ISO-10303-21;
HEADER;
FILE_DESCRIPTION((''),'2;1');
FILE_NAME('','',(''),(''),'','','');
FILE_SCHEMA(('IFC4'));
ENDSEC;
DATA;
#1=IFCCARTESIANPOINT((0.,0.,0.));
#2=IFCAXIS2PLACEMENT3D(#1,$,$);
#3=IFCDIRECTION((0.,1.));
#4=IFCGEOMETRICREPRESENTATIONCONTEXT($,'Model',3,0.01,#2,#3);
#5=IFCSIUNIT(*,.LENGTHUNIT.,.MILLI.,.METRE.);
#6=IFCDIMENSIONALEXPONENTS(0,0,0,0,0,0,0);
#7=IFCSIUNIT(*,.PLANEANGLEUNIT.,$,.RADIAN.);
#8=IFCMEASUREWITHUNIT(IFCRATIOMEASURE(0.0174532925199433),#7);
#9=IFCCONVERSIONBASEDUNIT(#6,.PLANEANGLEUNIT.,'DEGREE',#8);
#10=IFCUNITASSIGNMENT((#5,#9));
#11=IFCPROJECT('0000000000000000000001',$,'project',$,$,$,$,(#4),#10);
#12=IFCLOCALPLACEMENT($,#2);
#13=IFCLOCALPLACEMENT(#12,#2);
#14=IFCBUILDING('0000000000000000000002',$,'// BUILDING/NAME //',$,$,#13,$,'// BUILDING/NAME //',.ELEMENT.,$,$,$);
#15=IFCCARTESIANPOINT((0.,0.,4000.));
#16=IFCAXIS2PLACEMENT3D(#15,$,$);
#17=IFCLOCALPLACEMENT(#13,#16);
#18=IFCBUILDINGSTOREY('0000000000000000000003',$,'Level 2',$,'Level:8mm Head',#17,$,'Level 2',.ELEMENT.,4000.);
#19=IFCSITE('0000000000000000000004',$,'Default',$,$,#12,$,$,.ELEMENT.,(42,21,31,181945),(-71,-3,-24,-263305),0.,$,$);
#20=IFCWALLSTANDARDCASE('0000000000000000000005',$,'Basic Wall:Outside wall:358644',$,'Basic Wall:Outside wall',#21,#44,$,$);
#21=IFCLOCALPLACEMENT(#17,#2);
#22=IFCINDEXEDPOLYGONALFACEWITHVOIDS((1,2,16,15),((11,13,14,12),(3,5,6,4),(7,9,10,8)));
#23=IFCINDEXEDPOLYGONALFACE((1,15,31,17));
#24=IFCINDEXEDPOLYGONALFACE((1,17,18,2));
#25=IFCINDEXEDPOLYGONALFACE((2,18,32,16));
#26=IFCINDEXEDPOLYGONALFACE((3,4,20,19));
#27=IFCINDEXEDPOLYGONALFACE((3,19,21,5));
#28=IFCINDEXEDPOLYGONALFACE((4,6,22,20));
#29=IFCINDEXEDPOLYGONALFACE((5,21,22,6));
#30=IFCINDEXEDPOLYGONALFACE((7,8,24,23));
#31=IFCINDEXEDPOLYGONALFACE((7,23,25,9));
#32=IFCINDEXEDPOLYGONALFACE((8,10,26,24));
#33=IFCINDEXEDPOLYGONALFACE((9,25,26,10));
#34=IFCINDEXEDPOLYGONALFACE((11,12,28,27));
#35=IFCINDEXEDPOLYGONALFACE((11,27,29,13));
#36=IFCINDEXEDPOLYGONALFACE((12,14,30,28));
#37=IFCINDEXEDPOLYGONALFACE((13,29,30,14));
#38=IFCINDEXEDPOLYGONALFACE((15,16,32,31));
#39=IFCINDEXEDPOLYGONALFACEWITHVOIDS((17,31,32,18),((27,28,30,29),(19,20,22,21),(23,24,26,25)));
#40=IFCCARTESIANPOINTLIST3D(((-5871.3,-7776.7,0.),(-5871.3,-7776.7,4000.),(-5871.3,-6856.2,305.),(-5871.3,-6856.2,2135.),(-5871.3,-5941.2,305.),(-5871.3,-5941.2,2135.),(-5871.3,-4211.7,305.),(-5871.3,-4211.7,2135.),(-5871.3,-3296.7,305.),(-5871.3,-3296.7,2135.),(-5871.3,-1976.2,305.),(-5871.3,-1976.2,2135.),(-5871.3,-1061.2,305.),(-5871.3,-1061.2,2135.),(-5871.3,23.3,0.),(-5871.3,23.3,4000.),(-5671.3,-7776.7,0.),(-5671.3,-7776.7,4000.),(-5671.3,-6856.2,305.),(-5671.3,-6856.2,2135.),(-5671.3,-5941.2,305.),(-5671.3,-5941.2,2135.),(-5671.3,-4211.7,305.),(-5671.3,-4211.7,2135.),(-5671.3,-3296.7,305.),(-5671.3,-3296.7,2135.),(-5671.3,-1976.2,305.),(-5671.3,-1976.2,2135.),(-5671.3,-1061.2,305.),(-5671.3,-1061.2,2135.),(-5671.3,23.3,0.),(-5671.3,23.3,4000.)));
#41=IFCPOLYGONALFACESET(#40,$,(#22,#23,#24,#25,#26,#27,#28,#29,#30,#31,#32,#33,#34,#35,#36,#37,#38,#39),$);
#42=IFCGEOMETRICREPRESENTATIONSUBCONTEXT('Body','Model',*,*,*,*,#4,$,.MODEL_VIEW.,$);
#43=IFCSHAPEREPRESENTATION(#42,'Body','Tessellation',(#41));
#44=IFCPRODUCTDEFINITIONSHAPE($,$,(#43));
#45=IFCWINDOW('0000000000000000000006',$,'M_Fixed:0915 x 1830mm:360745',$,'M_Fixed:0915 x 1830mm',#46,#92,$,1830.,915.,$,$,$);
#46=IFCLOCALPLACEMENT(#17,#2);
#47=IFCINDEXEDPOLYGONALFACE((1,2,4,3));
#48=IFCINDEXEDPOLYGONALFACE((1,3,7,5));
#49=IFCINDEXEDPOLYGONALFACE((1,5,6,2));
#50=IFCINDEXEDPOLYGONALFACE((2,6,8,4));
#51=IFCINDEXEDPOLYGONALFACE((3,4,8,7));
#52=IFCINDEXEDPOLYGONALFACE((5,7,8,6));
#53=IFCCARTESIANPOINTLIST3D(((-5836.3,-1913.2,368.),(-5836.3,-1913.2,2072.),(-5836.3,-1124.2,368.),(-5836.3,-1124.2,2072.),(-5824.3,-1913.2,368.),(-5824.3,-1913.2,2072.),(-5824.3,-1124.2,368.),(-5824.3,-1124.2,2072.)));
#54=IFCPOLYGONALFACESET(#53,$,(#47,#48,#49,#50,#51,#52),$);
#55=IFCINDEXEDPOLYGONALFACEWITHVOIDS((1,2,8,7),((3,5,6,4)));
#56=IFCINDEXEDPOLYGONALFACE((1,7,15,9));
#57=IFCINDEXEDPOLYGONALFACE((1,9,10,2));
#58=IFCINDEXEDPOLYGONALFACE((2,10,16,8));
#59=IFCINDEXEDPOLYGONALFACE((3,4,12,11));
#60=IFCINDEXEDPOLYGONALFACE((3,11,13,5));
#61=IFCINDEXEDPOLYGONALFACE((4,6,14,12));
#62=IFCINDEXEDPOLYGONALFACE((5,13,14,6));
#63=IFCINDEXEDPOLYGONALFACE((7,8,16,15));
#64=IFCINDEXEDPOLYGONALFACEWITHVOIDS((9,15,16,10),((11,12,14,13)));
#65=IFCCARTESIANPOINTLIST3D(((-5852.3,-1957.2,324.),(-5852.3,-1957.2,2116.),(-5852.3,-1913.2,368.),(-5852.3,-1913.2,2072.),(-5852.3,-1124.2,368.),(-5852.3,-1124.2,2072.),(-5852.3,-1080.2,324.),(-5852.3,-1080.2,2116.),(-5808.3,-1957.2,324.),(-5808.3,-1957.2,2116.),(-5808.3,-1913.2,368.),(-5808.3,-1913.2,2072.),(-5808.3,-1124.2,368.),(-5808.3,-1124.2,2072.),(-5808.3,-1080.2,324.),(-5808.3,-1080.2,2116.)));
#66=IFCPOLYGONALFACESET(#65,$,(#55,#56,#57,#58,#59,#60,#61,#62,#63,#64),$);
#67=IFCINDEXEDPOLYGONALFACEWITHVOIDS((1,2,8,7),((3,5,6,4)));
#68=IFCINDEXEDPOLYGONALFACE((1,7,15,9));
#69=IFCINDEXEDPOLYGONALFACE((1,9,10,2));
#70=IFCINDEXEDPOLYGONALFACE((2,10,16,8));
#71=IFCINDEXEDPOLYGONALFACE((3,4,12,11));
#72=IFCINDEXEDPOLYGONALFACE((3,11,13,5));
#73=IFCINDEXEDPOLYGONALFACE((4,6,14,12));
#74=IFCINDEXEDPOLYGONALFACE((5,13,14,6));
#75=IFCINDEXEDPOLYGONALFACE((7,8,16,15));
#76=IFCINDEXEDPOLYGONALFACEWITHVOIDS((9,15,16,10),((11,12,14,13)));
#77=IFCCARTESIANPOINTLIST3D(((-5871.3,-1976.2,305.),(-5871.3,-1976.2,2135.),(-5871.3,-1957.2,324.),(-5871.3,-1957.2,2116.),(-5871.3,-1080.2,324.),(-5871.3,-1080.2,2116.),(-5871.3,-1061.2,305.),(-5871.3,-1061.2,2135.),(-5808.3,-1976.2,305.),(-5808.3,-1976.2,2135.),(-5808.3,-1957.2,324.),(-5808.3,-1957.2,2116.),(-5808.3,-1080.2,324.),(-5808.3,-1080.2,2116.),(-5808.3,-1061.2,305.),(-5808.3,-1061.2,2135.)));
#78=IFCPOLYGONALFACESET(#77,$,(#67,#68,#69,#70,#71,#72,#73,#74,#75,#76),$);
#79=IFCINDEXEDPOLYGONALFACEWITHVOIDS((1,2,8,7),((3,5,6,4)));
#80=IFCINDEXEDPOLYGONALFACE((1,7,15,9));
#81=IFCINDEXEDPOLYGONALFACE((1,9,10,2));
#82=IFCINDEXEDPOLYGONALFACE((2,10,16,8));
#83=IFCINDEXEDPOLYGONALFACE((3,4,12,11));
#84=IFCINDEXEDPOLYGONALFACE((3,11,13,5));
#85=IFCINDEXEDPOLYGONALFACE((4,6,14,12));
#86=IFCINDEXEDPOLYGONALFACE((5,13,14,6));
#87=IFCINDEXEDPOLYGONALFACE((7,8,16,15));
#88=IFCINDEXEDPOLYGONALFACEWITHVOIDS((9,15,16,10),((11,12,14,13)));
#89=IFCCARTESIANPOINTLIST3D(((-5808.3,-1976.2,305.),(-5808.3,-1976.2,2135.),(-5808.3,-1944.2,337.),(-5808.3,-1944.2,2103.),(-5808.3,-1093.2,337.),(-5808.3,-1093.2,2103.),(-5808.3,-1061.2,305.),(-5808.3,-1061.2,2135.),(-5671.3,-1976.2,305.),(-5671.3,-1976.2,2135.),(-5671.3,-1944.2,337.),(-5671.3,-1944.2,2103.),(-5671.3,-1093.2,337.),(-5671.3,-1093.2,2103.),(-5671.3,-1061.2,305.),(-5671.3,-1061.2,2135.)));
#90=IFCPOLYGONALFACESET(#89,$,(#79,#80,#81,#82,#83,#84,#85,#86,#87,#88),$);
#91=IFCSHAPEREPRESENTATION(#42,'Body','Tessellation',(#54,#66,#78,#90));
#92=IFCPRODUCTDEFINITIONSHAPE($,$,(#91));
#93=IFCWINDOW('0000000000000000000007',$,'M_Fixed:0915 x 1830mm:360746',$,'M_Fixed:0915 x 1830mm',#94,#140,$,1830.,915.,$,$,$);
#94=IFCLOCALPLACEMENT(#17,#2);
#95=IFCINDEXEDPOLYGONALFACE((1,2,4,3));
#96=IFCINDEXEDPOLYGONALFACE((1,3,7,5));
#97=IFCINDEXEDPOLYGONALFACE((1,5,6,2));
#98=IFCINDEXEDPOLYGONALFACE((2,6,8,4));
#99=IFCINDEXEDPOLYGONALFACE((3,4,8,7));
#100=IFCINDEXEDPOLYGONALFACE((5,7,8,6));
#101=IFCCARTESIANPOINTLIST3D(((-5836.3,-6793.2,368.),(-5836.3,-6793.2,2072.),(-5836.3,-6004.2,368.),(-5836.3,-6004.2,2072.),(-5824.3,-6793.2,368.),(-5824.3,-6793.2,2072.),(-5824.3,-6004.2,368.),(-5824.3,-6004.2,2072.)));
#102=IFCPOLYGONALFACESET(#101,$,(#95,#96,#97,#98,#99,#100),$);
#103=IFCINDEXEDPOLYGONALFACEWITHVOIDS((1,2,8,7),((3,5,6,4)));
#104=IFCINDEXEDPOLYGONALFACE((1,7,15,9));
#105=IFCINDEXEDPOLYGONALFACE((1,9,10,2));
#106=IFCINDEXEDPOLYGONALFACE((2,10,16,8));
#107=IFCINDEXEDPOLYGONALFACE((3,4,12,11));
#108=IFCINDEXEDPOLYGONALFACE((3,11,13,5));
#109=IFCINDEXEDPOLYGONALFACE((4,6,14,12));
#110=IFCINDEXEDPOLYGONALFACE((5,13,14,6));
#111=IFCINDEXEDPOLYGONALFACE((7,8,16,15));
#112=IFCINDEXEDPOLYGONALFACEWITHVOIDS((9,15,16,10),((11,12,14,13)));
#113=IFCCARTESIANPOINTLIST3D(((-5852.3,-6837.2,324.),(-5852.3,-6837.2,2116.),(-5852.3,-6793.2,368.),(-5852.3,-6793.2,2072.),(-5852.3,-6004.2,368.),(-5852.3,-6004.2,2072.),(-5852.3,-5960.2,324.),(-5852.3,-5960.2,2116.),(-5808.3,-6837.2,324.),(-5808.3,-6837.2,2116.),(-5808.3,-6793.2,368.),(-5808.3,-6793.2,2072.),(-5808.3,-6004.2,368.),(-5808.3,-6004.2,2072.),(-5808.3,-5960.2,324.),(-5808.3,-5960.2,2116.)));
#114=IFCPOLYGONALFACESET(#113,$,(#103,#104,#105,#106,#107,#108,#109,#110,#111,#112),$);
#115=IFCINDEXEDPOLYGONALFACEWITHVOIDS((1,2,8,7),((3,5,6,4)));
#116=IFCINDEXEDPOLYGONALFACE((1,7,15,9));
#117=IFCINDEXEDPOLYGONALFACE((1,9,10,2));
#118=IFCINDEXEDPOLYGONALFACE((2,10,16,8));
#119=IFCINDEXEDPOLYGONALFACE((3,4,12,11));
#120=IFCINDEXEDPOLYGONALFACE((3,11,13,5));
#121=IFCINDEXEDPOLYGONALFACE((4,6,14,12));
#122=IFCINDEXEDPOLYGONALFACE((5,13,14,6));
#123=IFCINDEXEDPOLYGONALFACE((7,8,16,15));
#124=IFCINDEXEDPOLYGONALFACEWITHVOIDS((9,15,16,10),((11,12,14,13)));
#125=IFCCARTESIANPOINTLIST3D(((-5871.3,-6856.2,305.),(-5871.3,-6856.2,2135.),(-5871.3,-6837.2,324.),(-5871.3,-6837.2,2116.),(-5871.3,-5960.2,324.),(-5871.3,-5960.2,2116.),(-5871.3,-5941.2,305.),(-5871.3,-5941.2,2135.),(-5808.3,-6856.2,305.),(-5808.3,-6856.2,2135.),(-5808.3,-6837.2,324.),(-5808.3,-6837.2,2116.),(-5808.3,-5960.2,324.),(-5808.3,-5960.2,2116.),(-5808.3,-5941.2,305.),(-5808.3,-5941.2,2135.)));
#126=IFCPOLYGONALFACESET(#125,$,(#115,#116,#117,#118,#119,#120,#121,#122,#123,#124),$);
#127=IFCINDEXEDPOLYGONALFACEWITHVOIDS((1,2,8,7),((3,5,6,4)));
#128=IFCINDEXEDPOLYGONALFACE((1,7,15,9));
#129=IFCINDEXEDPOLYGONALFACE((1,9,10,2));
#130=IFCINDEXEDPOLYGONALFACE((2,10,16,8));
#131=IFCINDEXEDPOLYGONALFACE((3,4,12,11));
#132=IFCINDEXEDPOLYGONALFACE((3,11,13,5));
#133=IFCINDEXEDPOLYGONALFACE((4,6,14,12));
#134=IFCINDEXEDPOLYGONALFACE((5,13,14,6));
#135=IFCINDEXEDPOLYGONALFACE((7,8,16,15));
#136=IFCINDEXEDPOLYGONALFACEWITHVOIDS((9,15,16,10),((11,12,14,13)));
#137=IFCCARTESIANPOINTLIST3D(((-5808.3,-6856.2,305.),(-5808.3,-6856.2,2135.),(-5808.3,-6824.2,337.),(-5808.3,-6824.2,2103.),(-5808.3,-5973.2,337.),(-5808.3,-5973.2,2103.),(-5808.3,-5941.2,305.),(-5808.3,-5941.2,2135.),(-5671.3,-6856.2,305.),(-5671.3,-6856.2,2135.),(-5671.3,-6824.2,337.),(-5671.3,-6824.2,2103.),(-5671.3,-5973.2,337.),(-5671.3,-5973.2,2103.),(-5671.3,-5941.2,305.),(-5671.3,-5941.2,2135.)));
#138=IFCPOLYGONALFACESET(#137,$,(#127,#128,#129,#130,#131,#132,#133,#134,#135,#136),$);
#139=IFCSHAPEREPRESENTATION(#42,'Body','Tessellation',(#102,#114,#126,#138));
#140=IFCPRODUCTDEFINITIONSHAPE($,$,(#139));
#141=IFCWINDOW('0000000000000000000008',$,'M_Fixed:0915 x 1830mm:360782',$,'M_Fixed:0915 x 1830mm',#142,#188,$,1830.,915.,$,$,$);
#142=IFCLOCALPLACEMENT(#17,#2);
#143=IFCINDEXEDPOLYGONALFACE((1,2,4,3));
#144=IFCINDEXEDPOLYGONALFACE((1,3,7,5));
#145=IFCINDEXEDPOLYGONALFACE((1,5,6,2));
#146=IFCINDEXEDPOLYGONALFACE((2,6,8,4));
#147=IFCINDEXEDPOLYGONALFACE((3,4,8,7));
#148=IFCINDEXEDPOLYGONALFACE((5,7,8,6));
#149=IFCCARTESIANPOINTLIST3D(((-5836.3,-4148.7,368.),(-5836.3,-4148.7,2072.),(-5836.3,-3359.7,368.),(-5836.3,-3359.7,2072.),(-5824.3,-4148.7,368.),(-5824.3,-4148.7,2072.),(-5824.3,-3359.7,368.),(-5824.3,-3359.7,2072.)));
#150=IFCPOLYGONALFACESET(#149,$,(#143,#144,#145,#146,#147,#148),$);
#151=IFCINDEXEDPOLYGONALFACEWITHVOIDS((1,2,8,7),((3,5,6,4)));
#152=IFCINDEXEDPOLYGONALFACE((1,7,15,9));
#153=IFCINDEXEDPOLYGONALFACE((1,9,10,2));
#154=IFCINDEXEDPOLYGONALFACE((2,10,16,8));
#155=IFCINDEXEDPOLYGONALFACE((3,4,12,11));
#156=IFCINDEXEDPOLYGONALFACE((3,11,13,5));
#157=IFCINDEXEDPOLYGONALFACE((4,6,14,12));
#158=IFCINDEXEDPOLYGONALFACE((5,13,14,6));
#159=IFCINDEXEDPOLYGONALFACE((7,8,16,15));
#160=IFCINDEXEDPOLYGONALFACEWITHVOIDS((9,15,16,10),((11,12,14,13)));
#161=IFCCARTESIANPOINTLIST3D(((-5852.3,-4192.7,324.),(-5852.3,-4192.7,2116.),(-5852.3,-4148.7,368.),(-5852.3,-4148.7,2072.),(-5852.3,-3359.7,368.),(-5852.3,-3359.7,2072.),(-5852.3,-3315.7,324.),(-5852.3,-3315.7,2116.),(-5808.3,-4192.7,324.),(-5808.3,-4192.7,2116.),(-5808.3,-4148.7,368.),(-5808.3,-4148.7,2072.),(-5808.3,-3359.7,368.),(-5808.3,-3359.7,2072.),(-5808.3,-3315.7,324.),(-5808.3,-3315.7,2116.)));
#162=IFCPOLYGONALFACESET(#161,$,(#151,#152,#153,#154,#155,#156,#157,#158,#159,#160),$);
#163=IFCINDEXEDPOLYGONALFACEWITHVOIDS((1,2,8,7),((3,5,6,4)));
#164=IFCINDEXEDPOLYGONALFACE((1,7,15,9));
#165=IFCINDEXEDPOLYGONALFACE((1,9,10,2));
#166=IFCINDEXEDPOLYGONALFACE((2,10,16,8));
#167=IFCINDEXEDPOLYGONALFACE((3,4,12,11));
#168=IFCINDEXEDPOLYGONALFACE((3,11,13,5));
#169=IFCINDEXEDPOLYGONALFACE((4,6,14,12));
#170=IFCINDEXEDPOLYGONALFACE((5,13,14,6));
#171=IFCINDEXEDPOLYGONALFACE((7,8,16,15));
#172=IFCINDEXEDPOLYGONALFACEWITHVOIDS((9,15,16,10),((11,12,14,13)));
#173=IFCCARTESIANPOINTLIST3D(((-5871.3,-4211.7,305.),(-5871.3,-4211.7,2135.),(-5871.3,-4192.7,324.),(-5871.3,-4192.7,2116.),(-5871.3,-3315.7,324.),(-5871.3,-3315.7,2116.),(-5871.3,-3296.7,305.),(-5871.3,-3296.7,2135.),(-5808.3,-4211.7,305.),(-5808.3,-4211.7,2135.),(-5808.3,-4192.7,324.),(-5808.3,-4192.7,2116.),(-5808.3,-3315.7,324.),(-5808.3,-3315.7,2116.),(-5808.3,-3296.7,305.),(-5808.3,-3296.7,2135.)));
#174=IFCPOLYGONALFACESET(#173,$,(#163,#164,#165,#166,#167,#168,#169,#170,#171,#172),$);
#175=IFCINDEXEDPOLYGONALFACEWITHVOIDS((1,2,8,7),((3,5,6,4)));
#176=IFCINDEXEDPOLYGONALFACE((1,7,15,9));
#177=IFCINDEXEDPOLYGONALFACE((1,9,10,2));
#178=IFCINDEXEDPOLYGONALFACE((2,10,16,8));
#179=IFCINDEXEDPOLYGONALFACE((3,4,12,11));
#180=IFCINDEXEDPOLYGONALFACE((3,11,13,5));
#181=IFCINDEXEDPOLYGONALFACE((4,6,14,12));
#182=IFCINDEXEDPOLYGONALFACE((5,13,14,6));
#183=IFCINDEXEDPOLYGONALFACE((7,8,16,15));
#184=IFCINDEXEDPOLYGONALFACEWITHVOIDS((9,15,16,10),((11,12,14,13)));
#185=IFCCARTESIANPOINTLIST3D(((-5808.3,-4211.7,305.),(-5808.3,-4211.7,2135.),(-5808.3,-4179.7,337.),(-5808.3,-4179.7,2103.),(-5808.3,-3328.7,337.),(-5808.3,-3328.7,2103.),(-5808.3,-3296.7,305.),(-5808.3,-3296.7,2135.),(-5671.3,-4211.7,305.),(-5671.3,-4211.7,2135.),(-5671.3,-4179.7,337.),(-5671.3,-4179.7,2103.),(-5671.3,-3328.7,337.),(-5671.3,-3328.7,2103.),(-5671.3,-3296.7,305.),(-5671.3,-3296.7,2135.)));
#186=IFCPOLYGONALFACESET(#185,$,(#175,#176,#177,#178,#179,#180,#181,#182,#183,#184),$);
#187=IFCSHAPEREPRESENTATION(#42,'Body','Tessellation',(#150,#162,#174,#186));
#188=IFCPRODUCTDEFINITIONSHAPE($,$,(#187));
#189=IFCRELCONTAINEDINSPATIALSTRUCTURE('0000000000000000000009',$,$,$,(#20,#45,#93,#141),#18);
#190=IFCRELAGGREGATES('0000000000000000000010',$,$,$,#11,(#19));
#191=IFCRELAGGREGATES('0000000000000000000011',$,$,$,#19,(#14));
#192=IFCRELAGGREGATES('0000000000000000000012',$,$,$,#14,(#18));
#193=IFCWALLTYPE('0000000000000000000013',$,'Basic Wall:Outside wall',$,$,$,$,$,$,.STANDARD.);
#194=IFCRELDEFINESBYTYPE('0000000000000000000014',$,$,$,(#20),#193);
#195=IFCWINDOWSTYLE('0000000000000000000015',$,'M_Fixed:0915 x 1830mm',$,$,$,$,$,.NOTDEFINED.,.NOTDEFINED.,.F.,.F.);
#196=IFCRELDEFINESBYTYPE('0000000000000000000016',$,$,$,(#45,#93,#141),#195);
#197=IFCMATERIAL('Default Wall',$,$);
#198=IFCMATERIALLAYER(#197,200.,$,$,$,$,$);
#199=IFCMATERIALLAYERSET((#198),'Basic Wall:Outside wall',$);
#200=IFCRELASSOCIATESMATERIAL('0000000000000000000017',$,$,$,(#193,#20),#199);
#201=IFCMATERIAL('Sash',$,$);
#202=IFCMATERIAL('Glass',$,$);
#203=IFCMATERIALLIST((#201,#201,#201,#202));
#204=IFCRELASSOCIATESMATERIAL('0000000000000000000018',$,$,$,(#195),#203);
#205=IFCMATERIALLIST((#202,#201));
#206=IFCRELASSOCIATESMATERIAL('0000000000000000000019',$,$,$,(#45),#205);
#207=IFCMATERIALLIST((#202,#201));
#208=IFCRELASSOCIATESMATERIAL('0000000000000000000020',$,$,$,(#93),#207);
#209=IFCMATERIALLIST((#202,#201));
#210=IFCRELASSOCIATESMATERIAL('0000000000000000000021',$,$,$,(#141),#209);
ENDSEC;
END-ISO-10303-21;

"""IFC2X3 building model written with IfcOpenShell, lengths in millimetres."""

from ifc_helpers import new_model, entity, si_unit, converted_unit, direction, frame, frame_2d, origin, place, context, subcontext, project, spatial, polyline, rectangle, outline, extrude, clip, halfspace, source, transform, mapped, material, material_list, layer, layer_set, layer_usage, type_object, type_shapes, element, fill, save


model = new_model("IFC2X3")

# Units and contexts
model_context = context("Model", 3, precision=0.01, world=origin(), true_north=direction((0.0, 1.0)))
body_context = subcontext(model_context, "Body", "Model", "MODEL_VIEW")
ifc_project = project(units=[si_unit("LENGTHUNIT", "METRE", prefix="MILLI"), converted_unit("PLANEANGLEUNIT", "DEGREE", entity("IfcRatioMeasure", 0.0174532925199433), si_unit("PLANEANGLEUNIT", "RADIAN"), dimensions=[0, 0, 0, 0, 0, 0, 0])], contexts=[model_context])

# Site, building, storey
site_placement = place(None, origin())
site = spatial("IfcSite", under=ifc_project, at=site_placement, Name="Default", CompositionType="ELEMENT", RefLatitude=(42, 21, 31, 181945), RefLongitude=(-71, -3, -24, -263305), RefElevation=0.0)
building_placement = place(site_placement, origin())
building = spatial("IfcBuilding", under=site, at=building_placement, Name="// BUILDING/NAME //", LongName="// BUILDING/NAME //", CompositionType="ELEMENT")
storey_placement = place(building_placement, frame((0.0, 0.0, 4000.0)))
storey = spatial("IfcBuildingStorey", under=building, at=storey_placement, Name="Level 2", ObjectType="Level:8mm Head", LongName="Level 2", CompositionType="ELEMENT", Elevation=4000.0)

# Shared definitions
ifc_material_1 = material(Name="Default Wall")
ifc_layer_1 = layer(ifc_material_1, 200.0)
ifc_layer_set_1 = layer_set([ifc_layer_1], Name="Basic Wall:Outside wall")
wall_type_1 = type_object("IfcWallType", Name="Basic Wall:Outside wall", PredefinedType="STANDARD", material=ifc_layer_set_1)
ifc_material_2 = material(Name="Glass")
ifc_material_3 = material(Name="Sash")
ifc_material_list_1 = material_list([ifc_material_3, ifc_material_3, ifc_material_3, ifc_material_2])
window_style = type_object("IfcWindowStyle", Name="M_Fixed:0915 x 1830mm", ConstructionType="NOTDEFINED", OperationType="NOTDEFINED", ParameterTakesPrecedence=False, Sizeable=False, material=ifc_material_list_1)
shared_shape = source(origin(), body_context, "Body", "SweptSolid", [
    extrude(rectangle(XDim=12.0, YDim=789.0, at=frame_2d((0.0, 0.0), x_axis=(1.0, 0.0))), frame((457.5, 159.0, 63.0), z_axis=(0.0, 0.0, 1.0), x_axis=(0.0, -1.0, 0.0)), (0.0, 0.0, 1.0), 1704.0),
    extrude(outline(polyline([(-438.5, -896.0), (438.5, -896.0), (438.5, 896.0), (-438.5, 896.0), (-438.5, -896.0)]), holes=[polyline([(-394.5, -852.0), (-394.5, 852.0), (394.5, 852.0), (394.5, -852.0), (-394.5, -852.0)])]), frame((457.5, 137.0, 915.0), z_axis=(0.0, 1.0, 0.0), x_axis=(1.0, 0.0, 0.0)), (0.0, 0.0, 1.0), 44.0),
    extrude(outline(polyline([(-457.5, -915.0), (457.5, -915.0), (457.5, 915.0), (-457.5, 915.0), (-457.5, -915.0)]), holes=[polyline([(-438.5, -896.0), (-438.5, 896.0), (438.5, 896.0), (438.5, -896.0), (-438.5, -896.0)])]), frame((457.5, 137.0, 915.0), z_axis=(0.0, 1.0, 0.0), x_axis=(1.0, 0.0, 0.0)), (0.0, 0.0, 1.0), 63.0),
    extrude(outline(polyline([(-457.5, -915.0), (457.5, -915.0), (457.5, 915.0), (-457.5, 915.0), (-457.5, -915.0)]), holes=[polyline([(-425.5, -883.0), (-425.5, 883.0), (425.5, 883.0), (425.5, -883.0), (-425.5, -883.0)])]), frame((457.5, 0.0, 915.0), z_axis=(0.0, 1.0, 0.0), x_axis=(1.0, 0.0, 0.0)), (0.0, 0.0, 1.0), 137.0),
])
type_shapes(window_style, [shared_shape])

# Wall, openings, windows
ifc_layer_usage_1 = layer_usage(ifc_layer_set_1, "AXIS2", "NEGATIVE", 100.0)
wall_1_placement = place(storey_placement, frame((-5771.3, -7776.7, 0.0), z_axis=(0.0, 0.0, 1.0), x_axis=(0.0, 1.0, 0.0)))
wall_1 = element("IfcWallStandardCase", 1, at=wall_1_placement, inside=storey, type_object=wall_type_1, material=ifc_layer_usage_1, Name="Basic Wall:Outside wall:358644", ObjectType="Basic Wall:Outside wall", context=body_context, shape_type="Clipping", body=[
    clip(extrude(rectangle(XDim=7800.0, YDim=200.0, at=frame_2d((3900.0, 0.0), x_axis=(-1.0, 0.0))), origin(), (0.0, 0.0, 1.0), 4000.0), halfspace(frame((0.0, 0.0, -4000.0)), True)),
])
opening_1_placement = place(wall_1_placement, frame((5800.5, -100.0, 305.0)))
opening_1 = element("IfcOpeningElement", 2, at=opening_1_placement, cuts=wall_1, ObjectType="Opening", context=body_context, shape_type="SweptSolid", body=[
    extrude(rectangle(XDim=1830.0, YDim=915.0, at=frame_2d((915.0, 457.5), x_axis=(1.0, 0.0))), frame((0.0, 0.0, 0.0), z_axis=(0.0, 1.0, 0.0), x_axis=(0.0, 0.0, 1.0)), (0.0, 0.0, 1.0), 200.0),
])
opening_2_placement = place(wall_1_placement, frame((920.5, -100.0, 305.0)))
opening_2 = element("IfcOpeningElement", 3, at=opening_2_placement, cuts=wall_1, ObjectType="Opening", context=body_context, shape_type="SweptSolid", body=[
    extrude(rectangle(XDim=1830.0, YDim=915.0, at=frame_2d((915.0, 457.5), x_axis=(1.0, 0.0))), frame((0.0, 0.0, 0.0), z_axis=(0.0, 1.0, 0.0), x_axis=(0.0, 0.0, 1.0)), (0.0, 0.0, 1.0), 200.0),
])
opening_3_placement = place(wall_1_placement, frame((3565.0, -100.0, 305.0)))
opening_3 = element("IfcOpeningElement", 4, at=opening_3_placement, cuts=wall_1, ObjectType="Opening", context=body_context, shape_type="SweptSolid", body=[
    extrude(rectangle(XDim=1830.0, YDim=915.0, at=frame_2d((915.0, 457.5), x_axis=(1.0, 0.0))), frame((0.0, 0.0, 0.0), z_axis=(0.0, 1.0, 0.0), x_axis=(0.0, 0.0, 1.0)), (0.0, 0.0, 1.0), 200.0),
])
ifc_material_list_2 = material_list([ifc_material_2, ifc_material_3])
window_1_placement = place(opening_1_placement, origin())
window_1 = element("IfcWindow", 5, at=window_1_placement, inside=storey, type_object=window_style, material=ifc_material_list_2, Name="M_Fixed:0915 x 1830mm:360745", ObjectType="M_Fixed:0915 x 1830mm", OverallHeight=1830.0, OverallWidth=915.0, context=body_context, shape_type="MappedRepresentation", body=[
    mapped(shared_shape, transform((0.0, 0.0, 0.0), scale=1.0)),
])
fill(opening_1, window_1)
ifc_material_list_3 = material_list([ifc_material_2, ifc_material_3])
window_2_placement = place(opening_2_placement, origin())
window_2 = element("IfcWindow", 6, at=window_2_placement, inside=storey, type_object=window_style, material=ifc_material_list_3, Name="M_Fixed:0915 x 1830mm:360746", ObjectType="M_Fixed:0915 x 1830mm", OverallHeight=1830.0, OverallWidth=915.0, context=body_context, shape_type="MappedRepresentation", body=[
    mapped(shared_shape, transform((0.0, 0.0, 0.0), scale=1.0)),
])
fill(opening_2, window_2)
ifc_material_list_4 = material_list([ifc_material_2, ifc_material_3])
window_3_placement = place(opening_3_placement, origin())
window_3 = element("IfcWindow", 7, at=window_3_placement, inside=storey, type_object=window_style, material=ifc_material_list_4, Name="M_Fixed:0915 x 1830mm:360782", ObjectType="M_Fixed:0915 x 1830mm", OverallHeight=1830.0, OverallWidth=915.0, context=body_context, shape_type="MappedRepresentation", body=[
    mapped(shared_shape, transform((0.0, 0.0, 0.0), scale=1.0)),
])
fill(opening_3, window_3)

save(model, "model.ifc")
